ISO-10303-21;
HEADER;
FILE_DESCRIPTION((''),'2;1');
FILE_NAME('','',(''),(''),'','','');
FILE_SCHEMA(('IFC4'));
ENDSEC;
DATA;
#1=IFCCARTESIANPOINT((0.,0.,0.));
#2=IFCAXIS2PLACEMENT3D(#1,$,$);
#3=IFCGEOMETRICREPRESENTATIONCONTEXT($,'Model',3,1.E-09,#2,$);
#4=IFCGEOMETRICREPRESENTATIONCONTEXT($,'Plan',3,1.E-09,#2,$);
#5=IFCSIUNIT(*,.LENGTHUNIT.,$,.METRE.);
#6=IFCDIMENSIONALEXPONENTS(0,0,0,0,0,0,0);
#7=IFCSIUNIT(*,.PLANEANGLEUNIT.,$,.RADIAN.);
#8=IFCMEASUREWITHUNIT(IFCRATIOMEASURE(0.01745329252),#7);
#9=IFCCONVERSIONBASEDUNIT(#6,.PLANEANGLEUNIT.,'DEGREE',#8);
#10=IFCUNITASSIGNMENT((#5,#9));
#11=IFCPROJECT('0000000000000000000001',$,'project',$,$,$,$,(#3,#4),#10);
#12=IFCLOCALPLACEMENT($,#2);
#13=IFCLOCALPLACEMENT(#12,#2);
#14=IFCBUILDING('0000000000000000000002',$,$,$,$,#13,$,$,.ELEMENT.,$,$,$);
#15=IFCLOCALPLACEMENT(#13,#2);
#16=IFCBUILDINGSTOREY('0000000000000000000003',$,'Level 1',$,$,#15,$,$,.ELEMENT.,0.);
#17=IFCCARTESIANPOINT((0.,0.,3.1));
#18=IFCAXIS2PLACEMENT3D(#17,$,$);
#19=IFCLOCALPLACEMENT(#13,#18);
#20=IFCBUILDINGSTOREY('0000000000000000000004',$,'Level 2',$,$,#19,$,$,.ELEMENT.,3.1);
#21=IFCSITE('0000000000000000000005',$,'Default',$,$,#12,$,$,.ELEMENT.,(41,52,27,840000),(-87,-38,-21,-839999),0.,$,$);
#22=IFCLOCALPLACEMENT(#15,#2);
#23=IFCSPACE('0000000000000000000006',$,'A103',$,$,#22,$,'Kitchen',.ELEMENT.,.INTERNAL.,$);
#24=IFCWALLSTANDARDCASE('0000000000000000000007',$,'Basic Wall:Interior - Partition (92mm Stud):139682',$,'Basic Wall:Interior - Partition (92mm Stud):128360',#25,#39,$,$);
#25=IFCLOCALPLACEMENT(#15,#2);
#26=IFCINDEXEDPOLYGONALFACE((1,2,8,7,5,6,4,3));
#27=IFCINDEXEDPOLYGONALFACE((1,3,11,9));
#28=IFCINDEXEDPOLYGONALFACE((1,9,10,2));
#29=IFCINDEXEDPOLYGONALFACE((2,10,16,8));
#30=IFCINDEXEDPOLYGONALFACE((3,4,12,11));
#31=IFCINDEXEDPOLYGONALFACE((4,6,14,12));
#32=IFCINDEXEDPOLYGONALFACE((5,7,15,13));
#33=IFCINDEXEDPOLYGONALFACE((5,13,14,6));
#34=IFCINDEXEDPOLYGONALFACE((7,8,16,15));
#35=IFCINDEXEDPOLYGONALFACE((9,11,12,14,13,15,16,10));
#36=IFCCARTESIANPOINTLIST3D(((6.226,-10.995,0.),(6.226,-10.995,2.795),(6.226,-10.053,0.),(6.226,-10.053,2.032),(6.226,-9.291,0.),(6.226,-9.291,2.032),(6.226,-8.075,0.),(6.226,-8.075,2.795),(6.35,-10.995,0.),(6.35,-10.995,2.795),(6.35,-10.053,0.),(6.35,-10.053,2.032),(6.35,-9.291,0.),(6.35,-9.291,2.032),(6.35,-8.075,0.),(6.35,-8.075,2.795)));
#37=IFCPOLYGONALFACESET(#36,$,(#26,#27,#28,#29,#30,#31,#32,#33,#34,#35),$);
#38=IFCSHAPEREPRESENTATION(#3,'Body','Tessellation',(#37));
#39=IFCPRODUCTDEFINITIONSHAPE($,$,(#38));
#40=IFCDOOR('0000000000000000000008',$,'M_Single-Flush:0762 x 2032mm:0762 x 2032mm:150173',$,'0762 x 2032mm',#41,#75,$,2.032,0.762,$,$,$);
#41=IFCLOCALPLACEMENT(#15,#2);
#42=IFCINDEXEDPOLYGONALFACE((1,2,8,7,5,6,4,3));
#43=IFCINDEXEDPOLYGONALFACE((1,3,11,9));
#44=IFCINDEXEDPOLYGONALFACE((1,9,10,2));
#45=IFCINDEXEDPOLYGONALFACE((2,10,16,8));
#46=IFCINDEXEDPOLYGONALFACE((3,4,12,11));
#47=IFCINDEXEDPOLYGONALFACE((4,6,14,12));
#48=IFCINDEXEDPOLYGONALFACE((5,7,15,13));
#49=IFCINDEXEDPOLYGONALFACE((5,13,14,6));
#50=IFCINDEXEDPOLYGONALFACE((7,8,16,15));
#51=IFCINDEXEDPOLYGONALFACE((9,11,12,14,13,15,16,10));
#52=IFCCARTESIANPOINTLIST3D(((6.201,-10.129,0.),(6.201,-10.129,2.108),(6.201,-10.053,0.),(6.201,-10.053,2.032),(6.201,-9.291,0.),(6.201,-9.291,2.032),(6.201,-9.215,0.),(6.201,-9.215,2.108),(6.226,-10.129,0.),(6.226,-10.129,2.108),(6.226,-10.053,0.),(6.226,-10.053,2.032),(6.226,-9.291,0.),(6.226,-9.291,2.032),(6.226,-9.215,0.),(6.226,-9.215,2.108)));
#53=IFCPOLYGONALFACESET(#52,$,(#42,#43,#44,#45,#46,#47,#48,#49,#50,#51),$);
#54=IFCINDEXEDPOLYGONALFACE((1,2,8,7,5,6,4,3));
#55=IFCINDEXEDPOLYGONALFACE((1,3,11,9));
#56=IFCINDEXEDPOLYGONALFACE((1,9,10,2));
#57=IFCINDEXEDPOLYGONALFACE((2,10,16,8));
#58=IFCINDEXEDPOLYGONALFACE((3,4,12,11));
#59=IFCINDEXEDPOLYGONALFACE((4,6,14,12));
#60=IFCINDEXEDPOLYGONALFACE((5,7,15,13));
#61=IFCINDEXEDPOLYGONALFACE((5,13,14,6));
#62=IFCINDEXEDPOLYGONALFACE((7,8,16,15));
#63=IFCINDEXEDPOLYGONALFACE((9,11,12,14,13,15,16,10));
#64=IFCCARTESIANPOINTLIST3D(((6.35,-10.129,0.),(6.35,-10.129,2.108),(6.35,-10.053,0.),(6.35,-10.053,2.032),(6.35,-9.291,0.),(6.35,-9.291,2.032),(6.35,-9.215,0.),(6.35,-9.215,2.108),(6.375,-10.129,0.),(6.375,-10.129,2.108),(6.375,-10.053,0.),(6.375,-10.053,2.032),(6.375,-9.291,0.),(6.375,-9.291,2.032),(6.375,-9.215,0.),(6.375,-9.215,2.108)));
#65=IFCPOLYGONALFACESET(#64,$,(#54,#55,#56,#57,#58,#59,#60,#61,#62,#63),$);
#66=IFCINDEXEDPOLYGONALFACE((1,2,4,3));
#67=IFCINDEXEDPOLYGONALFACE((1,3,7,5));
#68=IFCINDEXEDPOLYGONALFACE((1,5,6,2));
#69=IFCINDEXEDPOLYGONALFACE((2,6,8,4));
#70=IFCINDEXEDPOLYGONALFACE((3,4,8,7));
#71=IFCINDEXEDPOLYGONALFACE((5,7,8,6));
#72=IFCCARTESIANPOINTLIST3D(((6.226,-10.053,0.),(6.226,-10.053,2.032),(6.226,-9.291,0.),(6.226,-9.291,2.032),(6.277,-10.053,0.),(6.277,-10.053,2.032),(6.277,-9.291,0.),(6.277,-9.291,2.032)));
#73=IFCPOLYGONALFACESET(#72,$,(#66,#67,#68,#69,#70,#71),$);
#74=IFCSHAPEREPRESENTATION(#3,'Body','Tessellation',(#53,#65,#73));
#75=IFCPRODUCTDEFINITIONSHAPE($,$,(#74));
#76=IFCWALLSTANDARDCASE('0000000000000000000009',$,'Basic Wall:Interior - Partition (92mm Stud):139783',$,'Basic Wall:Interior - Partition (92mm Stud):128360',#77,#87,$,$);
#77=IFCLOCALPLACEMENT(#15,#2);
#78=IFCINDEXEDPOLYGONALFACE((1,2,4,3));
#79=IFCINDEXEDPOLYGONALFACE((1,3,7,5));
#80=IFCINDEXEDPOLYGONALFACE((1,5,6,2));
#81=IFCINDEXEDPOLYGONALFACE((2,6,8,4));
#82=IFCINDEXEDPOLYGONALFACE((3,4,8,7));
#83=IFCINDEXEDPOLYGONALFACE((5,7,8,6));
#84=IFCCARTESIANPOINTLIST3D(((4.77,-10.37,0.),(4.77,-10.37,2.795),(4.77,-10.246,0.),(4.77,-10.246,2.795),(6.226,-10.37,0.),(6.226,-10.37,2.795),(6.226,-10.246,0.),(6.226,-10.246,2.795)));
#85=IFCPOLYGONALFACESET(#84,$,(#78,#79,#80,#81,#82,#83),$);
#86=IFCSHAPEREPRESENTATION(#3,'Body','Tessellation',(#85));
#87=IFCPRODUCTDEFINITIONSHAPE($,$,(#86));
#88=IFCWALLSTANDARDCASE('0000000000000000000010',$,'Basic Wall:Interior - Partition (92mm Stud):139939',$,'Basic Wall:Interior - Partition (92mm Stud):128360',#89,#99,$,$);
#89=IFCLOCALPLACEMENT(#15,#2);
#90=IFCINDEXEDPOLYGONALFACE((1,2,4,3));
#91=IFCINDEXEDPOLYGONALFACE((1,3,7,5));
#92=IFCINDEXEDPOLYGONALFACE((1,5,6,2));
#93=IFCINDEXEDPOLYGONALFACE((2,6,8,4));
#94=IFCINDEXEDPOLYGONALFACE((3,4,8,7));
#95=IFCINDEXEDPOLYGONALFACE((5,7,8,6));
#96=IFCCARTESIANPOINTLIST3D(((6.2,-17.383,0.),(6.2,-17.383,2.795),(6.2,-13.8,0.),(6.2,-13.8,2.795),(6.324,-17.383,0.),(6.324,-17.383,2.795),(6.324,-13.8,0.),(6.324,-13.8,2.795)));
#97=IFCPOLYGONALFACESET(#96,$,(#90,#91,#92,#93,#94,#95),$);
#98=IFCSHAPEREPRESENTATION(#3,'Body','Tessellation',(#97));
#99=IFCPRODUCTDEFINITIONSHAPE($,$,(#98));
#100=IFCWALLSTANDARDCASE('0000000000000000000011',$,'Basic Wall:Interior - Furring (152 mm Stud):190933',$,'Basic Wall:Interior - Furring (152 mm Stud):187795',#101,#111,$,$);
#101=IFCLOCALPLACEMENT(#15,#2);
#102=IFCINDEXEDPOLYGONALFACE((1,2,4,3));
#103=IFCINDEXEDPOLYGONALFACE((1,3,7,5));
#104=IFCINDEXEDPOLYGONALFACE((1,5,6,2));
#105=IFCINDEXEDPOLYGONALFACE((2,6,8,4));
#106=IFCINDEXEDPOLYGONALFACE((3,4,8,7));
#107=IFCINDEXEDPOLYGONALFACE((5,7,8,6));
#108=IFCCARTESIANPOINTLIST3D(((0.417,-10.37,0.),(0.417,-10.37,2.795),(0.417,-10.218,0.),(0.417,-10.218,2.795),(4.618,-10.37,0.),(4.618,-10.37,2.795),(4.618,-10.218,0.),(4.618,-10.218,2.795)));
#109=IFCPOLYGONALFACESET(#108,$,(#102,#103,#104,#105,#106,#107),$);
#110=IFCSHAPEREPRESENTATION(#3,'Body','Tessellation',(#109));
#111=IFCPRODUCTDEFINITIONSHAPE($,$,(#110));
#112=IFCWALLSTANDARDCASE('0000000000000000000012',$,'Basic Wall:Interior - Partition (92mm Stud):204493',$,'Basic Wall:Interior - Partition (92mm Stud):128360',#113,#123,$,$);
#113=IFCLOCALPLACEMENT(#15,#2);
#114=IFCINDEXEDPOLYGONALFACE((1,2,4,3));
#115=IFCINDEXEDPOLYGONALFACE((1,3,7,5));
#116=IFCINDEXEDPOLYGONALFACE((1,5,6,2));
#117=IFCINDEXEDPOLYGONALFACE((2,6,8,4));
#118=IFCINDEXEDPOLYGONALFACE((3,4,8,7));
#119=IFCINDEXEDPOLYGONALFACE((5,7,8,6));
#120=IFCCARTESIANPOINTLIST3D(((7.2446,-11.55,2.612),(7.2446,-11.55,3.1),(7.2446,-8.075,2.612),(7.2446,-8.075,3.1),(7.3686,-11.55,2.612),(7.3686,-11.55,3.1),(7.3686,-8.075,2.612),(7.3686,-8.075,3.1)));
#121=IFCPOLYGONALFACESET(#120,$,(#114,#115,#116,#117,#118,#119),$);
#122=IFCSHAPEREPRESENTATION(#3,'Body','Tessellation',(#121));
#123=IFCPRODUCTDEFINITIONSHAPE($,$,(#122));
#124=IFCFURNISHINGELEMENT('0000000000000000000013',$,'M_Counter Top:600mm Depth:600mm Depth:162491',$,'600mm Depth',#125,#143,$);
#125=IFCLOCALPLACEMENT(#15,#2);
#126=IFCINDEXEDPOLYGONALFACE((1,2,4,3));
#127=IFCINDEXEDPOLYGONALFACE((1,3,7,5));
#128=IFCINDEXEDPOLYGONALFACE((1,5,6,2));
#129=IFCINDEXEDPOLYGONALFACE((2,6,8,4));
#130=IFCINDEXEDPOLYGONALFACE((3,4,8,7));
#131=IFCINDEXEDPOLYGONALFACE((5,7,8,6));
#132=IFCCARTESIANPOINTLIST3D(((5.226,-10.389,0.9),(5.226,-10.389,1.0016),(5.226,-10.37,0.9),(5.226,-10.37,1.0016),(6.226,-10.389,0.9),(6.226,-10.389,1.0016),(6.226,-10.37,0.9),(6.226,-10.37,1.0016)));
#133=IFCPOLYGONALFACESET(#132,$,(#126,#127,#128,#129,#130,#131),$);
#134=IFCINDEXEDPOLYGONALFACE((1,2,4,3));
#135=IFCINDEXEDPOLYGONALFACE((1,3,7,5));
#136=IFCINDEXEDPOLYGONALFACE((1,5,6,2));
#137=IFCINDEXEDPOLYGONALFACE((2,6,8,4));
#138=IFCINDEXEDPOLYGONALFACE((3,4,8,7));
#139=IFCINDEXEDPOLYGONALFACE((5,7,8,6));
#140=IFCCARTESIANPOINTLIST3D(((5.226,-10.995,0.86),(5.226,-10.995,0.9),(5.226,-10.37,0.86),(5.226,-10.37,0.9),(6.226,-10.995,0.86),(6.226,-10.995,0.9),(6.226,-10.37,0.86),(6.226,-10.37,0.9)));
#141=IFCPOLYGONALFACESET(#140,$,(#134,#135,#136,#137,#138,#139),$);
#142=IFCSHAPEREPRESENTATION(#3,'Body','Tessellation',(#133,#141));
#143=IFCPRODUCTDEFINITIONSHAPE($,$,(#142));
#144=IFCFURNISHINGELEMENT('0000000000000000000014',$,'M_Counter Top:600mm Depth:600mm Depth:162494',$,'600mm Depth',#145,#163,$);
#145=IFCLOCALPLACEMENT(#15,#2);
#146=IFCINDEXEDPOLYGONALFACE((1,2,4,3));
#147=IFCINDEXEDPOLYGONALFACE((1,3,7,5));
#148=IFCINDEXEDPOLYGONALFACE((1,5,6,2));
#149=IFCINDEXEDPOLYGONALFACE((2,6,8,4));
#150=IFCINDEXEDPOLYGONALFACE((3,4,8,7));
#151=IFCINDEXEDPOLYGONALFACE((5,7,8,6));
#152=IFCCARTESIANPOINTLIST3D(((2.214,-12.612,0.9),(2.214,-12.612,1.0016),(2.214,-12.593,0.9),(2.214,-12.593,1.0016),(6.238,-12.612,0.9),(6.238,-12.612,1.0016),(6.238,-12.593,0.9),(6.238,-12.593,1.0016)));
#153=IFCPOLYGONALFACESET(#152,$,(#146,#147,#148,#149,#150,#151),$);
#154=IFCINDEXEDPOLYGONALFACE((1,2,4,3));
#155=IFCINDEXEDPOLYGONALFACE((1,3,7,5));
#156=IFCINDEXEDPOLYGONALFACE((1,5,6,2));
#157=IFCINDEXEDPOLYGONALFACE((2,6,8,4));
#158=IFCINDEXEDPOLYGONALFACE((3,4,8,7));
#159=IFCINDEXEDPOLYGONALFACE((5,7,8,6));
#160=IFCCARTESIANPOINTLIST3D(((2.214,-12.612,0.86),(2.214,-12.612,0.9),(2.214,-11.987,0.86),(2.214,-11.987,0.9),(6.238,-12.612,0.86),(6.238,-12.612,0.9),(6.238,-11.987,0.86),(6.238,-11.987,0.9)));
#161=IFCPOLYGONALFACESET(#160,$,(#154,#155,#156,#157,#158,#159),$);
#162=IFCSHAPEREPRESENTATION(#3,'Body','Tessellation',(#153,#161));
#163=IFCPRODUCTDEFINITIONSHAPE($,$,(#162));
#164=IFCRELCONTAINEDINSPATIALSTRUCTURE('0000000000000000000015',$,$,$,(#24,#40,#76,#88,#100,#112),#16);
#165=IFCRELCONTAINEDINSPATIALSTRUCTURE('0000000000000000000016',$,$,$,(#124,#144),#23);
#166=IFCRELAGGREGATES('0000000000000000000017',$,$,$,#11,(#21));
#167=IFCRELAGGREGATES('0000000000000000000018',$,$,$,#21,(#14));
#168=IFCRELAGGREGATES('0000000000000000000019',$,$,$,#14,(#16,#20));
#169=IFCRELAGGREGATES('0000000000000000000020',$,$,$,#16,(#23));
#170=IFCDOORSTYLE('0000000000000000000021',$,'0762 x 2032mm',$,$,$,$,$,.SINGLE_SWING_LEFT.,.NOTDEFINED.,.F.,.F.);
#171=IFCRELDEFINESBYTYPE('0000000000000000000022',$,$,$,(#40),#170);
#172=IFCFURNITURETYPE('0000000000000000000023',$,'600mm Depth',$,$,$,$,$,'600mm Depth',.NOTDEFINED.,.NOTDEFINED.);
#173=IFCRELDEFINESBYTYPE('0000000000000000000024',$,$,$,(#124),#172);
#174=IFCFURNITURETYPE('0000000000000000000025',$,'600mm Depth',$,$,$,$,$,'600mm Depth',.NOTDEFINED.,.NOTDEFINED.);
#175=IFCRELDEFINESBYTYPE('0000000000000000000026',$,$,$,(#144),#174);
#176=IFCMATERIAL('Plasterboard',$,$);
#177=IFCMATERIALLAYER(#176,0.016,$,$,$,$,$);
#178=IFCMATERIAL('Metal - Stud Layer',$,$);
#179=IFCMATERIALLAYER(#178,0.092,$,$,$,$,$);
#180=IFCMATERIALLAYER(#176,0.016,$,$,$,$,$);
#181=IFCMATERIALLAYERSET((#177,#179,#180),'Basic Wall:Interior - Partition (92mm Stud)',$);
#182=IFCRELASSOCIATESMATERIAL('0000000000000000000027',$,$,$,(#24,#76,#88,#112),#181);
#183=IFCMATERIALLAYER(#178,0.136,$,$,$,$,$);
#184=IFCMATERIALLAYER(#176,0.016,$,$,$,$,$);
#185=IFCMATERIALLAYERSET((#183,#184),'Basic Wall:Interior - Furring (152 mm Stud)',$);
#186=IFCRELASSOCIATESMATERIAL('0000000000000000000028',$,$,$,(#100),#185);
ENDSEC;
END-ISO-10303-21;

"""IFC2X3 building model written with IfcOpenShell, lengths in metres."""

from ifc_helpers import new_model, entity, si_unit, converted_unit, frame, frame_2d, origin, origin_2d_with_axis, place, context, project, spatial, polyline, rectangle, outline, extrude, source, transform, mapped, material, layer, layer_set, layer_usage, type_object, type_shapes, element, fill, save


model = new_model("IFC2X3")

# Units and contexts
model_context = context("Model", 3, precision=1e-09, world=origin())
plan_context = context("Plan", 3, precision=1e-09, world=origin())
ifc_project = project(units=[si_unit("LENGTHUNIT", "METRE"), converted_unit("PLANEANGLEUNIT", "DEGREE", entity("IfcRatioMeasure", 0.01745329252), si_unit("PLANEANGLEUNIT", "RADIAN"), dimensions=[0, 0, 0, 0, 0, 0, 0])], contexts=[model_context, plan_context])

# Site, building, storey
site_placement = place(None, origin())
site = spatial("IfcSite", under=ifc_project, at=site_placement, Name="Default", CompositionType="ELEMENT", RefLatitude=(41, 52, 27, 840000), RefLongitude=(-87, -38, -21, -839999), RefElevation=0.0)
building_placement = place(site_placement, origin())
building = spatial("IfcBuilding", under=site, at=building_placement, CompositionType="ELEMENT")
storey_1_placement = place(building_placement, origin())
storey_1 = spatial("IfcBuildingStorey", under=building, at=storey_1_placement, Name="Level 1", CompositionType="ELEMENT", Elevation=0.0)

# Shared definitions
ifc_material_1 = material(Name="Metal - Stud Layer")
ifc_material_2 = material(Name="Plasterboard")

# Wall, opening, door
ifc_layer_1 = layer(ifc_material_2, 0.016)
ifc_layer_2 = layer(ifc_material_1, 0.092)
ifc_layer_3 = layer(ifc_material_2, 0.016)
ifc_layer_set_1 = layer_set([ifc_layer_1, ifc_layer_2, ifc_layer_3], Name="Basic Wall:Interior - Partition (92mm Stud)")
ifc_layer_usage_1 = layer_usage(ifc_layer_set_1, "AXIS2", "NEGATIVE", 0.062)
wall_1_placement = place(storey_1_placement, frame((6.288, -10.995, 0.0), z_axis=(0.0, 0.0, 1.0), x_axis=(0.0, 1.0, 0.0)))
wall_1 = element("IfcWallStandardCase", 1, at=wall_1_placement, inside=storey_1, material=ifc_layer_usage_1, Name="Basic Wall:Interior - Partition (92mm Stud):139682", ObjectType="Basic Wall:Interior - Partition (92mm Stud):128360", context=model_context, shape_type="SweptSolid", body=[
    extrude(rectangle(XDim=2.92, YDim=0.124, at=frame_2d((1.46, 0.0), x_axis=(-1.0, 0.0))), origin(), (0.0, 0.0, 1.0), 2.795),
])
opening_1_placement = place(wall_1_placement, frame((0.942, -0.062, 0.0)))
opening_1 = element("IfcOpeningElement", 2, at=opening_1_placement, cuts=wall_1, ObjectType="Opening", context=model_context, shape_type="SweptSolid", body=[
    extrude(rectangle(XDim=0.762, YDim=2.032, at=frame_2d((1.016, 0.381), x_axis=(0.0, -1.0))), frame((0.0, 0.0, 0.0), z_axis=(0.0, 1.0, 0.0), x_axis=(0.0, 0.0, 1.0)), (0.0, 0.0, 1.0), 0.124),
])
door_style_1 = type_object("IfcDoorStyle", Name="0762 x 2032mm", ConstructionType="NOTDEFINED", OperationType="SINGLE_SWING_LEFT", ParameterTakesPrecedence=False, Sizeable=False)
shared_shape_1 = source(origin(), model_context, "Body", "SweptSolid", [
    extrude(outline(polyline([(-0.457, -1.073), (0.457, -1.073), (0.457, 1.035), (0.381, 1.035), (0.381, -0.997), (-0.381, -0.997), (-0.381, 1.035), (-0.457, 1.035), (-0.457, -1.073)])), frame((0.381, 0.149, 1.035), z_axis=(0.0, -1.0, 0.0), x_axis=(-1.0, 0.0, 0.0)), (0.0, 0.0, 1.0), 0.025),
    extrude(outline(polyline([(-1.073, -0.457), (1.035, -0.457), (1.035, -0.381), (-0.997, -0.381), (-0.997, 0.381), (1.035, 0.381), (1.035, 0.457), (-1.073, 0.457), (-1.073, -0.457)])), frame((0.381, 0.0, 1.035), z_axis=(0.0, -1.0, 0.0), x_axis=(0.0, 0.0, -1.0)), (0.0, 0.0, 1.0), 0.025),
    extrude(rectangle(XDim=0.762, YDim=0.051, at=origin_2d_with_axis()), frame((0.381, 0.0985, 0.0)), (0.0, 0.0, 1.0), 2.032),
])
type_shapes(door_style_1, [shared_shape_1])
door_1_placement = place(opening_1_placement, origin())
door_1 = element("IfcDoor", 3, at=door_1_placement, inside=storey_1, type_object=door_style_1, Name="M_Single-Flush:0762 x 2032mm:0762 x 2032mm:150173", ObjectType="0762 x 2032mm", OverallHeight=2.032, OverallWidth=0.762, context=model_context, shape_type="MappedRepresentation", body=[
    mapped(shared_shape_1, transform((0.0, 0.0, 0.0), scale=1.0)),
])
fill(opening_1, door_1)

# Walls
ifc_layer_usage_2 = layer_usage(ifc_layer_set_1, "AXIS2", "NEGATIVE", 0.062)
wall_2_placement = place(storey_1_placement, frame((4.77, -10.308, 0.0)))
element("IfcWallStandardCase", 4, at=wall_2_placement, inside=storey_1, material=ifc_layer_usage_2, Name="Basic Wall:Interior - Partition (92mm Stud):139783", ObjectType="Basic Wall:Interior - Partition (92mm Stud):128360", context=model_context, shape_type="SweptSolid", body=[
    extrude(rectangle(XDim=1.456, YDim=0.124, at=frame_2d((0.728, 0.0), x_axis=(-1.0, 0.0))), origin(), (0.0, 0.0, 1.0), 2.795),
])
ifc_layer_usage_3 = layer_usage(ifc_layer_set_1, "AXIS2", "NEGATIVE", 0.062)
wall_3_placement = place(storey_1_placement, frame((6.262, -13.8, 0.0), z_axis=(0.0, 0.0, 1.0), x_axis=(0.0, -1.0, 0.0)))
element("IfcWallStandardCase", 5, at=wall_3_placement, inside=storey_1, material=ifc_layer_usage_3, Name="Basic Wall:Interior - Partition (92mm Stud):139939", ObjectType="Basic Wall:Interior - Partition (92mm Stud):128360", context=model_context, shape_type="SweptSolid", body=[
    extrude(rectangle(XDim=3.583, YDim=0.124, at=frame_2d((1.7915, 0.0), x_axis=(-1.0, 0.0))), origin(), (0.0, 0.0, 1.0), 2.795),
])

# Shared definitions
storey_2_placement = place(building_placement, frame((0.0, 0.0, 3.1)))
storey_2 = spatial("IfcBuildingStorey", under=building, at=storey_2_placement, Name="Level 2", CompositionType="ELEMENT", Elevation=3.1)

# Walls
ifc_layer_4 = layer(ifc_material_1, 0.136)
ifc_layer_5 = layer(ifc_material_2, 0.016)
ifc_layer_set_2 = layer_set([ifc_layer_4, ifc_layer_5], Name="Basic Wall:Interior - Furring (152 mm Stud)")
ifc_layer_usage_4 = layer_usage(ifc_layer_set_2, "AXIS2", "NEGATIVE", 0.076)
wall_4_placement = place(storey_1_placement, frame((0.417, -10.294, 0.0)))
element("IfcWallStandardCase", 6, at=wall_4_placement, inside=storey_1, material=ifc_layer_usage_4, Name="Basic Wall:Interior - Furring (152 mm Stud):190933", ObjectType="Basic Wall:Interior - Furring (152 mm Stud):187795", context=model_context, shape_type="SweptSolid", body=[
    extrude(rectangle(XDim=4.201, YDim=0.152, at=frame_2d((2.1005, 0.0), x_axis=(-1.0, 0.0))), origin(), (0.0, 0.0, 1.0), 2.795),
])
ifc_layer_usage_5 = layer_usage(ifc_layer_set_1, "AXIS2", "NEGATIVE", 0.062)
wall_5_placement = place(storey_1_placement, frame((7.3066, -11.55, 2.612), z_axis=(0.0, 0.0, 1.0), x_axis=(0.0, 1.0, 0.0)))
element("IfcWallStandardCase", 7, at=wall_5_placement, inside=storey_1, material=ifc_layer_usage_5, Name="Basic Wall:Interior - Partition (92mm Stud):204493", ObjectType="Basic Wall:Interior - Partition (92mm Stud):128360", context=model_context, shape_type="SweptSolid", body=[
    extrude(rectangle(XDim=3.475, YDim=0.124, at=frame_2d((1.7375, 0.0), x_axis=(-1.0, 0.0))), origin(), (0.0, 0.0, 1.0), 0.488),
])

# Shared definitions
space_1_placement = place(storey_1_placement, origin())
space_1 = spatial("IfcSpace", under=storey_1, at=space_1_placement, Name="A103", LongName="Kitchen", CompositionType="ELEMENT", InteriorOrExteriorSpace="INTERNAL")

# Furnishing elements
furniture_type_1 = type_object("IfcFurnitureType", Name="600mm Depth", ElementType="600mm Depth", AssemblyPlace="NOTDEFINED")
shared_shape_2 = source(origin(), model_context, "Body", "SweptSolid", [
    extrude(rectangle(XDim=0.0191, YDim=1.0, at=origin_2d_with_axis()), frame((-0.7005, -0.0095, 0.9), z_axis=(0.0, 0.0, 1.0), x_axis=(0.0, -1.0, 0.0)), (0.0, 0.0, 1.0), 0.1016),
    extrude(rectangle(XDim=1.0, YDim=0.625, at=origin_2d_with_axis()), frame((-0.7005, -0.3125, 0.86), z_axis=(0.0, 0.0, 1.0), x_axis=(-1.0, 0.0, 0.0)), (0.0, 0.0, 1.0), 0.04),
])
type_shapes(furniture_type_1, [shared_shape_2])
furnishing_1_placement = place(space_1_placement, frame((6.4265, -10.37, 0.0)))
element("IfcFurnishingElement", 8, at=furnishing_1_placement, inside=space_1, type_object=furniture_type_1, Name="M_Counter Top:600mm Depth:600mm Depth:162491", ObjectType="600mm Depth", context=model_context, shape_type="MappedRepresentation", body=[
    mapped(shared_shape_2, transform((0.0, 0.0, 0.0), scale=1.0)),
])
furniture_type_2 = type_object("IfcFurnitureType", Name="600mm Depth", ElementType="600mm Depth", AssemblyPlace="NOTDEFINED")
shared_shape_3 = source(origin(), model_context, "Body", "SweptSolid", [
    extrude(rectangle(XDim=0.0191, YDim=4.024, at=origin_2d_with_axis()), frame((0.8115, -0.0095, 0.9), z_axis=(0.0, 0.0, 1.0), x_axis=(0.0, -1.0, 0.0)), (0.0, 0.0, 1.0), 0.1016),
    extrude(rectangle(XDim=4.024, YDim=0.625, at=origin_2d_with_axis()), frame((0.8115, -0.3125, 0.86), z_axis=(0.0, 0.0, 1.0), x_axis=(-1.0, 0.0, 0.0)), (0.0, 0.0, 1.0), 0.04),
])
type_shapes(furniture_type_2, [shared_shape_3])
furnishing_2_placement = place(space_1_placement, frame((5.0375, -12.612, 0.0), z_axis=(0.0, 0.0, 1.0), x_axis=(-1.0, 0.0, 0.0)))
element("IfcFurnishingElement", 9, at=furnishing_2_placement, inside=space_1, type_object=furniture_type_2, Name="M_Counter Top:600mm Depth:600mm Depth:162494", ObjectType="600mm Depth", context=model_context, shape_type="MappedRepresentation", body=[
    mapped(shared_shape_3, transform((0.0, 0.0, 0.0), scale=1.0)),
])

save(model, "model.ifc")
